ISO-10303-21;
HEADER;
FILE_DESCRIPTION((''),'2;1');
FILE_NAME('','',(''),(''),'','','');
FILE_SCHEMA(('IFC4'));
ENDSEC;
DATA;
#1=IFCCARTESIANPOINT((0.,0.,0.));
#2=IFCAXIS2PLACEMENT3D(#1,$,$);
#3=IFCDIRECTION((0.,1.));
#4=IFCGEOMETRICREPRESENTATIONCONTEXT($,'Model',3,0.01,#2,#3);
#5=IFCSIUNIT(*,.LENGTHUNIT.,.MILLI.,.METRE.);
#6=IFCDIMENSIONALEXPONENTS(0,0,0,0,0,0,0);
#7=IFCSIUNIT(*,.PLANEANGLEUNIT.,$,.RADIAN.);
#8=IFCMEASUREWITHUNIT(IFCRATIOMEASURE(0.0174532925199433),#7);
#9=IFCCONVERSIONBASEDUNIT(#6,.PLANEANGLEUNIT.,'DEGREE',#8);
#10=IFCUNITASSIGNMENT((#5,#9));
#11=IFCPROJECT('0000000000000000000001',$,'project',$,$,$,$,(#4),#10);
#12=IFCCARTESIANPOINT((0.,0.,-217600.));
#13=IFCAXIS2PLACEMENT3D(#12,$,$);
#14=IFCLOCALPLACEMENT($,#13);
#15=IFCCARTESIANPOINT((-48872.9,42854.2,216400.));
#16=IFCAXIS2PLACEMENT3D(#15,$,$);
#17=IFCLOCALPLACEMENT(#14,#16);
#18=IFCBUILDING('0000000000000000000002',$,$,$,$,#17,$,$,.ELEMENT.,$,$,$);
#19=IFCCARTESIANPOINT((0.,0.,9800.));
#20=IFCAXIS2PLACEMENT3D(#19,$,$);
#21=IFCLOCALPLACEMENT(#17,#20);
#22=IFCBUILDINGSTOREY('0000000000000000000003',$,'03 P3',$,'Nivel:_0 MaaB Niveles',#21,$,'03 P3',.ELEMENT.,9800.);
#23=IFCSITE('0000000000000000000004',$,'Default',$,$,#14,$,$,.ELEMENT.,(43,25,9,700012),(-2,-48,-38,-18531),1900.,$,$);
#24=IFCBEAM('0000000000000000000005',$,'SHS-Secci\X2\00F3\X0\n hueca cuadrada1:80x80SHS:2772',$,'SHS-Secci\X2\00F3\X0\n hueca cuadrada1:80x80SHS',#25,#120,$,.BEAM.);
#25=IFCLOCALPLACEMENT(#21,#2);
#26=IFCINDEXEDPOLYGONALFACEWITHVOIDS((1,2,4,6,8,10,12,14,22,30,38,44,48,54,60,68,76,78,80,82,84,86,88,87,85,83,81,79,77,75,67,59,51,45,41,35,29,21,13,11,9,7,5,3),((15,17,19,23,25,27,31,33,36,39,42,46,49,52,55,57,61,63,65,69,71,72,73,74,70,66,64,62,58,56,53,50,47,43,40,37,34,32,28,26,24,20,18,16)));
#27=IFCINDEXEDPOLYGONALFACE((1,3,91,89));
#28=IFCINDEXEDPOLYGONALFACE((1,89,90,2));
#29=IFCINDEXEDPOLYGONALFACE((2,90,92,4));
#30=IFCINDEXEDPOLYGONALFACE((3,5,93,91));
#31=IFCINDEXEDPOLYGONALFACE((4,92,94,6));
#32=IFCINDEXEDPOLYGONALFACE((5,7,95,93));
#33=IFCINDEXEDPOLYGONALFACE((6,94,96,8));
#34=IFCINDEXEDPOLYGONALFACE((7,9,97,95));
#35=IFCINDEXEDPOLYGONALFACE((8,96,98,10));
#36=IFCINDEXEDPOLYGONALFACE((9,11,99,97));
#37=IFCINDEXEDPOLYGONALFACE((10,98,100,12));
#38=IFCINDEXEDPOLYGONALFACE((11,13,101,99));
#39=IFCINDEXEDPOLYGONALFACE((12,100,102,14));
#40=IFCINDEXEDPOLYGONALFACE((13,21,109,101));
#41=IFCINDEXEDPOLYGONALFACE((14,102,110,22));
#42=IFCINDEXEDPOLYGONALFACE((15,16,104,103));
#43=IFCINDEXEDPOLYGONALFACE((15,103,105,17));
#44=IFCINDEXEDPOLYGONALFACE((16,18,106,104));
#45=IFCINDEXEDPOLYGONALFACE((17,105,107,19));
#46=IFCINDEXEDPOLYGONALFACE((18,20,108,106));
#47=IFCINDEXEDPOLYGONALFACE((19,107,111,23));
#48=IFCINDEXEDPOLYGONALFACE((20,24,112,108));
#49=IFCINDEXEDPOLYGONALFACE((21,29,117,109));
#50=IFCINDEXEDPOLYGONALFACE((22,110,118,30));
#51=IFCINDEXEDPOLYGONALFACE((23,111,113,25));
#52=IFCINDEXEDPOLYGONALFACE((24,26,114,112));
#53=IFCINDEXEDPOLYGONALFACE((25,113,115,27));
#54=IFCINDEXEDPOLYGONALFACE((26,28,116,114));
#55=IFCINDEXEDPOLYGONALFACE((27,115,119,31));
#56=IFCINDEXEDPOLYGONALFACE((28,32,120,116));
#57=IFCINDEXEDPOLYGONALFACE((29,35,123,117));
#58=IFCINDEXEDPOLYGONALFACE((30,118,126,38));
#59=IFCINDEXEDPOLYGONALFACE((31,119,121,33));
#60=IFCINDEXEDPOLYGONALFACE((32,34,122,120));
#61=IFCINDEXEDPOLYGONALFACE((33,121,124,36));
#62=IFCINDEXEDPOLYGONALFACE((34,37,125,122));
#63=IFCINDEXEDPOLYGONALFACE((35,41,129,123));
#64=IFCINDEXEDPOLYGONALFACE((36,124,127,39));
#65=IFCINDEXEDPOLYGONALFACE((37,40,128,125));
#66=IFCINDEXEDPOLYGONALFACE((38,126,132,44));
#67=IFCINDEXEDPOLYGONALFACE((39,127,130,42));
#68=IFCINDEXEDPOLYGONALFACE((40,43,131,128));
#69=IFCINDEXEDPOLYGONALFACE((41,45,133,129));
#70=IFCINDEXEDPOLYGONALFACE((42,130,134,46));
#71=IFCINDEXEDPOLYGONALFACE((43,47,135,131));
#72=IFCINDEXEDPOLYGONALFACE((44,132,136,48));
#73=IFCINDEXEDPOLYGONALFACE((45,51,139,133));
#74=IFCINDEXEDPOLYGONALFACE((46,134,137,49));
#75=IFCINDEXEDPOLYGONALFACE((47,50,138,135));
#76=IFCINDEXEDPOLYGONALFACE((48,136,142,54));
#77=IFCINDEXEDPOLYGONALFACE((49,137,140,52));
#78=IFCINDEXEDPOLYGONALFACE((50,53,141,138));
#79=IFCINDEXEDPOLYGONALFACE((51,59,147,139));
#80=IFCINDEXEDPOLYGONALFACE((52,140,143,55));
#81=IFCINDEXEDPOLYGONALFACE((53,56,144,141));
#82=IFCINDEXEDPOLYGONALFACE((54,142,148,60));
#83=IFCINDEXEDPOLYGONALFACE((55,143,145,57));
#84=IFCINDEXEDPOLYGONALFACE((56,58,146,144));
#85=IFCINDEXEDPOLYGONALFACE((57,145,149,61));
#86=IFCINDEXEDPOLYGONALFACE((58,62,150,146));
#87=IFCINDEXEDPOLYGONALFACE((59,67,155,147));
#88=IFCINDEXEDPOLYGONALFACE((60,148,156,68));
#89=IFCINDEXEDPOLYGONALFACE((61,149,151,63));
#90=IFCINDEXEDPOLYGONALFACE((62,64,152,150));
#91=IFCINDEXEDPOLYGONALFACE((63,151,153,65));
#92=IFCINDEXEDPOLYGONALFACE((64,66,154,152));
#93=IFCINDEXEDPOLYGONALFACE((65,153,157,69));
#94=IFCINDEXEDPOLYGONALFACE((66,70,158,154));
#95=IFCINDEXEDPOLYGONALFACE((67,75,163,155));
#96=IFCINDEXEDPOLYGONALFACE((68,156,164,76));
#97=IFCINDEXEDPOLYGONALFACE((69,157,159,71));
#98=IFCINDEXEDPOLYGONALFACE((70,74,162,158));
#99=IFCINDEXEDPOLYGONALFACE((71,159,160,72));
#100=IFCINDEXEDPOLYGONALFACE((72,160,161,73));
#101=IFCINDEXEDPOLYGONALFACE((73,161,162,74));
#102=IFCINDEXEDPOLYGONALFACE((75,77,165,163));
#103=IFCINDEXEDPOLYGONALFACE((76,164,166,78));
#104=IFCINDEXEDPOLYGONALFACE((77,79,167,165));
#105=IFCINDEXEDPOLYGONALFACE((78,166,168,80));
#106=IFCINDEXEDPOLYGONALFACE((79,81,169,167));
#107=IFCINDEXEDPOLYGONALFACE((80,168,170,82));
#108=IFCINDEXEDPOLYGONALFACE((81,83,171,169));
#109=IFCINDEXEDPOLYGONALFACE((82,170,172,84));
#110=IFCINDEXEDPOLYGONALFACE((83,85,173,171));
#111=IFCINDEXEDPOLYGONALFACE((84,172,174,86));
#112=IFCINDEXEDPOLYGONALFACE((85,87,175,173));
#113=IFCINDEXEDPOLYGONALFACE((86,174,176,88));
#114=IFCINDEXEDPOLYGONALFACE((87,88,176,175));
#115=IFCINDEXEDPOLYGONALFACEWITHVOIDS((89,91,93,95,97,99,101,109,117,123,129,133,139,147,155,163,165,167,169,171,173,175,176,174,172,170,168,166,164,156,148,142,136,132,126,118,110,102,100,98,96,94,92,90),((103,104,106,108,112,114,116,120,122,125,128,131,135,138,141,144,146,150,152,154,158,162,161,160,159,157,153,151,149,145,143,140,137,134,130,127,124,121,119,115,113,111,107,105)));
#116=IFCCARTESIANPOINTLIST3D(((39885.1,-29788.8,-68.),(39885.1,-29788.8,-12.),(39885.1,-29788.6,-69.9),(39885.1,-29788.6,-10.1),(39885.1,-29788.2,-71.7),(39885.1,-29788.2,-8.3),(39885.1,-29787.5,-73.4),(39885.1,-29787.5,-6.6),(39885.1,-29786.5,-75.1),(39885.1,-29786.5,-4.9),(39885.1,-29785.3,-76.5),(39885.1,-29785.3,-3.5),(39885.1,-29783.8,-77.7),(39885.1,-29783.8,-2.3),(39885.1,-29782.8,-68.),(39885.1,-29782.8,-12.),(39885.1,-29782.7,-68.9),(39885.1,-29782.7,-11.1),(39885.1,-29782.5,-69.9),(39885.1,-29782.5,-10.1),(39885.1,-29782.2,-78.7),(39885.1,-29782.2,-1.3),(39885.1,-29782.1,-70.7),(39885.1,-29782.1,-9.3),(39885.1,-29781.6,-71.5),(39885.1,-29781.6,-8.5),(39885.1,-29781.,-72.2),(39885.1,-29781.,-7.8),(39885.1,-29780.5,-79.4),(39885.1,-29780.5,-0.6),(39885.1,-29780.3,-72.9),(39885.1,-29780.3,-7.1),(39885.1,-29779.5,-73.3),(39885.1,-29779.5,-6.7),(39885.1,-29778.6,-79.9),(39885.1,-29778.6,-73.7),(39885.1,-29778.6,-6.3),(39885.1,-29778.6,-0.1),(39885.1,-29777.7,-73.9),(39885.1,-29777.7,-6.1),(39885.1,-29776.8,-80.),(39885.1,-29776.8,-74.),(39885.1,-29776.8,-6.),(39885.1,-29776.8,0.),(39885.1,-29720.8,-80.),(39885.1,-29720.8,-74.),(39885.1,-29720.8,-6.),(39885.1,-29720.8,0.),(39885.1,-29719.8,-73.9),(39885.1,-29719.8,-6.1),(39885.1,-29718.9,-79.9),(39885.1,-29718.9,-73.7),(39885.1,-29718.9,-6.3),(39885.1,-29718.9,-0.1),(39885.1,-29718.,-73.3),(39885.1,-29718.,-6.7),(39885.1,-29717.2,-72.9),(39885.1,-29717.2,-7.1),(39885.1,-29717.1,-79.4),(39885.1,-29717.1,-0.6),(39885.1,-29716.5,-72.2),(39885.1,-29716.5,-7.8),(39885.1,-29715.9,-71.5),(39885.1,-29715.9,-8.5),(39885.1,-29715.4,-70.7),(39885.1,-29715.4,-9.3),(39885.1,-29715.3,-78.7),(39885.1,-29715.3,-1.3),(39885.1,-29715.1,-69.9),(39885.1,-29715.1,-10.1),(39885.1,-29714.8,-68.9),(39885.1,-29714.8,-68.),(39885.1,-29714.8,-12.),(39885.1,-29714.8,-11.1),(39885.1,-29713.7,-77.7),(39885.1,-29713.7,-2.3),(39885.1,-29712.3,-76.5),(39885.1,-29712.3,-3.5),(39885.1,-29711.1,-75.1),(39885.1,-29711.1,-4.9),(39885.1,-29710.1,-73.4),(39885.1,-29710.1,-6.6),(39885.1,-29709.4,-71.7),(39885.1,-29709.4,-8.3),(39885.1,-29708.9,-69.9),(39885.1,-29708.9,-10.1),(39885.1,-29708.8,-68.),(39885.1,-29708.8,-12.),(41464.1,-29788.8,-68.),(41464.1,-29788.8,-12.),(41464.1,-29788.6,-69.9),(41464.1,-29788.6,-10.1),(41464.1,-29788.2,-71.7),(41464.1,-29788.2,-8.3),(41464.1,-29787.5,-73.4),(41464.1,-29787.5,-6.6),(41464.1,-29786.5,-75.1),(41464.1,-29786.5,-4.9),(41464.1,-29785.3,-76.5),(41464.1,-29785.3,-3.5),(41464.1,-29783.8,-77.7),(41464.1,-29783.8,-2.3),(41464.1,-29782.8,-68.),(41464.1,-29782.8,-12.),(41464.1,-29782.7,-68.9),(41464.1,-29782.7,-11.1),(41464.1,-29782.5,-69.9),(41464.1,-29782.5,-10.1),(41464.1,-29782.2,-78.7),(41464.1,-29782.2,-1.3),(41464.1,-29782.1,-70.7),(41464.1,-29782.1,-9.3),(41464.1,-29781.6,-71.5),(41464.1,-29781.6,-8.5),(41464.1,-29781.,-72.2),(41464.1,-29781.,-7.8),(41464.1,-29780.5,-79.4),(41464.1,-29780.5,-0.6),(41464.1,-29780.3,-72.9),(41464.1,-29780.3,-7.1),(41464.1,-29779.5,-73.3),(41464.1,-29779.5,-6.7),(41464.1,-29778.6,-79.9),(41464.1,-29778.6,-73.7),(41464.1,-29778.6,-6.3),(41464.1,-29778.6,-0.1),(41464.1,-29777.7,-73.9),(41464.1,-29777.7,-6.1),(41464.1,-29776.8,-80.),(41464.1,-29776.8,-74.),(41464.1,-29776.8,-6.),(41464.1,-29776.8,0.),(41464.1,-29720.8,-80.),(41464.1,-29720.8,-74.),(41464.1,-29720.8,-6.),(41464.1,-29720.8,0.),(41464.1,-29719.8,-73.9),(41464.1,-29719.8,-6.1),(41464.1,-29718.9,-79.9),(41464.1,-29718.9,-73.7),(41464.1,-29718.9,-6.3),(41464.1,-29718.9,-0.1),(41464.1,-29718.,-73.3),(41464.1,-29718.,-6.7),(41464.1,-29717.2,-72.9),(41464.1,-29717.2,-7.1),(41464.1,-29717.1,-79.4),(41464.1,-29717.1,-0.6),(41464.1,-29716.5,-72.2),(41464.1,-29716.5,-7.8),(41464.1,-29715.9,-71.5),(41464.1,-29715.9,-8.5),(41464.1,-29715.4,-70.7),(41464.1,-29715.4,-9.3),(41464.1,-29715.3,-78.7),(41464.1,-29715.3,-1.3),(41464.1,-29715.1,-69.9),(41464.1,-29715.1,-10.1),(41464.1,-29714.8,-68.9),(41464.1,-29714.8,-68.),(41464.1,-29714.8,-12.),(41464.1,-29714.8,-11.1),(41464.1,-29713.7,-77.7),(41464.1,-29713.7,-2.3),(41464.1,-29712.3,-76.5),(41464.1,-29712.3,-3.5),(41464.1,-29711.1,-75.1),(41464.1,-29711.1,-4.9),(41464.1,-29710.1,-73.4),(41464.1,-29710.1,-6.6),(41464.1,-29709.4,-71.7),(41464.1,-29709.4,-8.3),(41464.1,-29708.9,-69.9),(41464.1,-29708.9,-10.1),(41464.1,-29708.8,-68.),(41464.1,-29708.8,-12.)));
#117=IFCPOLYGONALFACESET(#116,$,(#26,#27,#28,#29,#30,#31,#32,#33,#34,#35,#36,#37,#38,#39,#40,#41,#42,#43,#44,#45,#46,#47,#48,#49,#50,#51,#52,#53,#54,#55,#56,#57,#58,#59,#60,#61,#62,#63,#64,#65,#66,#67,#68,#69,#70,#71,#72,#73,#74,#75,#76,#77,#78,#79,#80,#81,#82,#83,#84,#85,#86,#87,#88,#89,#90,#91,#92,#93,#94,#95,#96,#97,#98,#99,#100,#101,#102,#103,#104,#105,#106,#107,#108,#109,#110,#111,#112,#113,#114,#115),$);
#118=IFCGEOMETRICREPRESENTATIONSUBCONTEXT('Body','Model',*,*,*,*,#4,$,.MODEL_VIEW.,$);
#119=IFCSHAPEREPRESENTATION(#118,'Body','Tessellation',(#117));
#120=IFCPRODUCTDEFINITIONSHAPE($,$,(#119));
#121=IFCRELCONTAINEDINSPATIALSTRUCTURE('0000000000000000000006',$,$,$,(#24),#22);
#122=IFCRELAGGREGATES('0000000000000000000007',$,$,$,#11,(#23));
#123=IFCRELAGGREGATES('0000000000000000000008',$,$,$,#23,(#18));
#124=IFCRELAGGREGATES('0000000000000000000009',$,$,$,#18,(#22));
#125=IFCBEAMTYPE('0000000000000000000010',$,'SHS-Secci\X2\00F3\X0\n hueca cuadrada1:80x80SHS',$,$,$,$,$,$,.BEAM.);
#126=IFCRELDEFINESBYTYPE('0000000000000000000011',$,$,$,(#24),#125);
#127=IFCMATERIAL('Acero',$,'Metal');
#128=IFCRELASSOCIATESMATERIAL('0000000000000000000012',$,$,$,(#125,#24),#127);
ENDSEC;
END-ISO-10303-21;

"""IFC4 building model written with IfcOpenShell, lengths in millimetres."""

from ifc_helpers import new_model, entity, si_unit, converted_unit, direction, frame, origin, place, context, subcontext, project, spatial, indexed_curve, outline, extrude, source, transform, mapped, material, type_object, type_shapes, element, save


model = new_model("IFC4")

# Units and contexts
model_context = context("Model", 3, precision=0.01, world=origin(), true_north=direction((0.0, 1.0)))
body_context = subcontext(model_context, "Body", "Model", "MODEL_VIEW")
ifc_project = project(units=[si_unit("LENGTHUNIT", "METRE", prefix="MILLI"), converted_unit("PLANEANGLEUNIT", "DEGREE", entity("IfcRatioMeasure", 0.0174532925199433), si_unit("PLANEANGLEUNIT", "RADIAN"), dimensions=[0, 0, 0, 0, 0, 0, 0])], contexts=[model_context])

# Site, building, storey
site_placement = place(None, frame((0.0, 0.0, -217600.0)))
site = spatial("IfcSite", under=ifc_project, at=site_placement, Name="Default", CompositionType="ELEMENT", RefLatitude=(43, 25, 9, 700012), RefLongitude=(-2, -48, -38, -18531), RefElevation=1900.0)
building_placement = place(site_placement, frame((-48872.9, 42854.2, 216400.0)))
building = spatial("IfcBuilding", under=site, at=building_placement, CompositionType="ELEMENT")
storey_placement = place(building_placement, frame((0.0, 0.0, 9800.0)))
storey = spatial("IfcBuildingStorey", under=building, at=storey_placement, Name="03 P3", ObjectType="Nivel:_0 MaaB Niveles", LongName="03 P3", CompositionType="ELEMENT", Elevation=9800.0)

# Shared definitions
ifc_material_1 = material(Name="Acero", Category="Metal")

# Beam
beam_type_1 = type_object("IfcBeamType", Name="SHS-Sección hueca cuadrada1:80x80SHS", PredefinedType="BEAM", material=ifc_material_1)
shared_shape_1 = source(origin(), body_context, "Body", "SweptSolid", [
    extrude(outline(indexed_curve([(-40.0, -28.0), (-39.9, -29.9), (-39.4, -31.7), (-38.7, -33.4), (-37.7, -35.1), (-36.5, -36.5), (-35.1, -37.7), (-33.4, -38.7), (-31.7, -39.4), (-29.9, -39.9), (-28.0, -40.0), (28.0, -40.0), (29.9, -39.9), (31.7, -39.4), (33.4, -38.7), (35.1, -37.7), (36.5, -36.5), (37.7, -35.1), (38.7, -33.4), (39.4, -31.7), (39.9, -29.9), (40.0, -28.0), (40.0, 28.0), (39.9, 29.9), (39.4, 31.7), (38.7, 33.4), (37.7, 35.1), (36.5, 36.5), (35.1, 37.7), (33.4, 38.7), (31.7, 39.4), (29.9, 39.9), (28.0, 40.0), (-28.0, 40.0), (-29.9, 39.9), (-31.7, 39.4), (-33.4, 38.7), (-35.1, 37.7), (-36.5, 36.5), (-37.7, 35.1), (-38.7, 33.4), (-39.4, 31.7), (-39.9, 29.9), (-40.0, 28.0), (-40.0, -28.0)], self_intersect=False), holes=[indexed_curve([(28.0, -34.0), (-28.0, -34.0), (-28.9, -33.9), (-29.9, -33.7), (-30.7, -33.3), (-31.5, -32.9), (-32.2, -32.2), (-32.9, -31.5), (-33.3, -30.7), (-33.7, -29.9), (-33.9, -28.9), (-34.0, -28.0), (-34.0, 28.0), (-33.9, 28.9), (-33.7, 29.9), (-33.3, 30.7), (-32.9, 31.5), (-32.2, 32.2), (-31.5, 32.9), (-30.7, 33.3), (-29.9, 33.7), (-28.9, 33.9), (-28.0, 34.0), (28.0, 34.0), (28.9, 33.9), (29.9, 33.7), (30.7, 33.3), (31.5, 32.9), (32.2, 32.2), (32.9, 31.5), (33.3, 30.7), (33.7, 29.9), (33.9, 28.9), (34.0, 28.0), (34.0, -28.0), (33.9, -28.9), (33.7, -29.9), (33.3, -30.7), (32.9, -31.5), (32.2, -32.2), (31.5, -32.9), (30.7, -33.3), (29.9, -33.7), (28.9, -33.9), (28.0, -34.0)], self_intersect=False)]), frame((-733.0, 0.0, 0.0), z_axis=(1.0, 0.0, 0.0), x_axis=(0.0, -1.0, 0.0)), (0.0, 0.0, 1.0), 1579.0),
])
type_shapes(beam_type_1, [shared_shape_1])
beam_1_placement = place(storey_placement, frame((40731.1, -29748.8, -40.0), z_axis=(0.0, 0.0, 1.0), x_axis=(-1.0, 0.0, 0.0)))
element("IfcBeam", 1, at=beam_1_placement, inside=storey, type_object=beam_type_1, material=ifc_material_1, Name="SHS-Sección hueca cuadrada1:80x80SHS:2772", ObjectType="SHS-Sección hueca cuadrada1:80x80SHS", PredefinedType="BEAM", context=body_context, shape_type="MappedRepresentation", body=[
    mapped(shared_shape_1, transform((0.0, 0.0, 0.0), scale=1.0)),
])

save(model, "model.ifc")
